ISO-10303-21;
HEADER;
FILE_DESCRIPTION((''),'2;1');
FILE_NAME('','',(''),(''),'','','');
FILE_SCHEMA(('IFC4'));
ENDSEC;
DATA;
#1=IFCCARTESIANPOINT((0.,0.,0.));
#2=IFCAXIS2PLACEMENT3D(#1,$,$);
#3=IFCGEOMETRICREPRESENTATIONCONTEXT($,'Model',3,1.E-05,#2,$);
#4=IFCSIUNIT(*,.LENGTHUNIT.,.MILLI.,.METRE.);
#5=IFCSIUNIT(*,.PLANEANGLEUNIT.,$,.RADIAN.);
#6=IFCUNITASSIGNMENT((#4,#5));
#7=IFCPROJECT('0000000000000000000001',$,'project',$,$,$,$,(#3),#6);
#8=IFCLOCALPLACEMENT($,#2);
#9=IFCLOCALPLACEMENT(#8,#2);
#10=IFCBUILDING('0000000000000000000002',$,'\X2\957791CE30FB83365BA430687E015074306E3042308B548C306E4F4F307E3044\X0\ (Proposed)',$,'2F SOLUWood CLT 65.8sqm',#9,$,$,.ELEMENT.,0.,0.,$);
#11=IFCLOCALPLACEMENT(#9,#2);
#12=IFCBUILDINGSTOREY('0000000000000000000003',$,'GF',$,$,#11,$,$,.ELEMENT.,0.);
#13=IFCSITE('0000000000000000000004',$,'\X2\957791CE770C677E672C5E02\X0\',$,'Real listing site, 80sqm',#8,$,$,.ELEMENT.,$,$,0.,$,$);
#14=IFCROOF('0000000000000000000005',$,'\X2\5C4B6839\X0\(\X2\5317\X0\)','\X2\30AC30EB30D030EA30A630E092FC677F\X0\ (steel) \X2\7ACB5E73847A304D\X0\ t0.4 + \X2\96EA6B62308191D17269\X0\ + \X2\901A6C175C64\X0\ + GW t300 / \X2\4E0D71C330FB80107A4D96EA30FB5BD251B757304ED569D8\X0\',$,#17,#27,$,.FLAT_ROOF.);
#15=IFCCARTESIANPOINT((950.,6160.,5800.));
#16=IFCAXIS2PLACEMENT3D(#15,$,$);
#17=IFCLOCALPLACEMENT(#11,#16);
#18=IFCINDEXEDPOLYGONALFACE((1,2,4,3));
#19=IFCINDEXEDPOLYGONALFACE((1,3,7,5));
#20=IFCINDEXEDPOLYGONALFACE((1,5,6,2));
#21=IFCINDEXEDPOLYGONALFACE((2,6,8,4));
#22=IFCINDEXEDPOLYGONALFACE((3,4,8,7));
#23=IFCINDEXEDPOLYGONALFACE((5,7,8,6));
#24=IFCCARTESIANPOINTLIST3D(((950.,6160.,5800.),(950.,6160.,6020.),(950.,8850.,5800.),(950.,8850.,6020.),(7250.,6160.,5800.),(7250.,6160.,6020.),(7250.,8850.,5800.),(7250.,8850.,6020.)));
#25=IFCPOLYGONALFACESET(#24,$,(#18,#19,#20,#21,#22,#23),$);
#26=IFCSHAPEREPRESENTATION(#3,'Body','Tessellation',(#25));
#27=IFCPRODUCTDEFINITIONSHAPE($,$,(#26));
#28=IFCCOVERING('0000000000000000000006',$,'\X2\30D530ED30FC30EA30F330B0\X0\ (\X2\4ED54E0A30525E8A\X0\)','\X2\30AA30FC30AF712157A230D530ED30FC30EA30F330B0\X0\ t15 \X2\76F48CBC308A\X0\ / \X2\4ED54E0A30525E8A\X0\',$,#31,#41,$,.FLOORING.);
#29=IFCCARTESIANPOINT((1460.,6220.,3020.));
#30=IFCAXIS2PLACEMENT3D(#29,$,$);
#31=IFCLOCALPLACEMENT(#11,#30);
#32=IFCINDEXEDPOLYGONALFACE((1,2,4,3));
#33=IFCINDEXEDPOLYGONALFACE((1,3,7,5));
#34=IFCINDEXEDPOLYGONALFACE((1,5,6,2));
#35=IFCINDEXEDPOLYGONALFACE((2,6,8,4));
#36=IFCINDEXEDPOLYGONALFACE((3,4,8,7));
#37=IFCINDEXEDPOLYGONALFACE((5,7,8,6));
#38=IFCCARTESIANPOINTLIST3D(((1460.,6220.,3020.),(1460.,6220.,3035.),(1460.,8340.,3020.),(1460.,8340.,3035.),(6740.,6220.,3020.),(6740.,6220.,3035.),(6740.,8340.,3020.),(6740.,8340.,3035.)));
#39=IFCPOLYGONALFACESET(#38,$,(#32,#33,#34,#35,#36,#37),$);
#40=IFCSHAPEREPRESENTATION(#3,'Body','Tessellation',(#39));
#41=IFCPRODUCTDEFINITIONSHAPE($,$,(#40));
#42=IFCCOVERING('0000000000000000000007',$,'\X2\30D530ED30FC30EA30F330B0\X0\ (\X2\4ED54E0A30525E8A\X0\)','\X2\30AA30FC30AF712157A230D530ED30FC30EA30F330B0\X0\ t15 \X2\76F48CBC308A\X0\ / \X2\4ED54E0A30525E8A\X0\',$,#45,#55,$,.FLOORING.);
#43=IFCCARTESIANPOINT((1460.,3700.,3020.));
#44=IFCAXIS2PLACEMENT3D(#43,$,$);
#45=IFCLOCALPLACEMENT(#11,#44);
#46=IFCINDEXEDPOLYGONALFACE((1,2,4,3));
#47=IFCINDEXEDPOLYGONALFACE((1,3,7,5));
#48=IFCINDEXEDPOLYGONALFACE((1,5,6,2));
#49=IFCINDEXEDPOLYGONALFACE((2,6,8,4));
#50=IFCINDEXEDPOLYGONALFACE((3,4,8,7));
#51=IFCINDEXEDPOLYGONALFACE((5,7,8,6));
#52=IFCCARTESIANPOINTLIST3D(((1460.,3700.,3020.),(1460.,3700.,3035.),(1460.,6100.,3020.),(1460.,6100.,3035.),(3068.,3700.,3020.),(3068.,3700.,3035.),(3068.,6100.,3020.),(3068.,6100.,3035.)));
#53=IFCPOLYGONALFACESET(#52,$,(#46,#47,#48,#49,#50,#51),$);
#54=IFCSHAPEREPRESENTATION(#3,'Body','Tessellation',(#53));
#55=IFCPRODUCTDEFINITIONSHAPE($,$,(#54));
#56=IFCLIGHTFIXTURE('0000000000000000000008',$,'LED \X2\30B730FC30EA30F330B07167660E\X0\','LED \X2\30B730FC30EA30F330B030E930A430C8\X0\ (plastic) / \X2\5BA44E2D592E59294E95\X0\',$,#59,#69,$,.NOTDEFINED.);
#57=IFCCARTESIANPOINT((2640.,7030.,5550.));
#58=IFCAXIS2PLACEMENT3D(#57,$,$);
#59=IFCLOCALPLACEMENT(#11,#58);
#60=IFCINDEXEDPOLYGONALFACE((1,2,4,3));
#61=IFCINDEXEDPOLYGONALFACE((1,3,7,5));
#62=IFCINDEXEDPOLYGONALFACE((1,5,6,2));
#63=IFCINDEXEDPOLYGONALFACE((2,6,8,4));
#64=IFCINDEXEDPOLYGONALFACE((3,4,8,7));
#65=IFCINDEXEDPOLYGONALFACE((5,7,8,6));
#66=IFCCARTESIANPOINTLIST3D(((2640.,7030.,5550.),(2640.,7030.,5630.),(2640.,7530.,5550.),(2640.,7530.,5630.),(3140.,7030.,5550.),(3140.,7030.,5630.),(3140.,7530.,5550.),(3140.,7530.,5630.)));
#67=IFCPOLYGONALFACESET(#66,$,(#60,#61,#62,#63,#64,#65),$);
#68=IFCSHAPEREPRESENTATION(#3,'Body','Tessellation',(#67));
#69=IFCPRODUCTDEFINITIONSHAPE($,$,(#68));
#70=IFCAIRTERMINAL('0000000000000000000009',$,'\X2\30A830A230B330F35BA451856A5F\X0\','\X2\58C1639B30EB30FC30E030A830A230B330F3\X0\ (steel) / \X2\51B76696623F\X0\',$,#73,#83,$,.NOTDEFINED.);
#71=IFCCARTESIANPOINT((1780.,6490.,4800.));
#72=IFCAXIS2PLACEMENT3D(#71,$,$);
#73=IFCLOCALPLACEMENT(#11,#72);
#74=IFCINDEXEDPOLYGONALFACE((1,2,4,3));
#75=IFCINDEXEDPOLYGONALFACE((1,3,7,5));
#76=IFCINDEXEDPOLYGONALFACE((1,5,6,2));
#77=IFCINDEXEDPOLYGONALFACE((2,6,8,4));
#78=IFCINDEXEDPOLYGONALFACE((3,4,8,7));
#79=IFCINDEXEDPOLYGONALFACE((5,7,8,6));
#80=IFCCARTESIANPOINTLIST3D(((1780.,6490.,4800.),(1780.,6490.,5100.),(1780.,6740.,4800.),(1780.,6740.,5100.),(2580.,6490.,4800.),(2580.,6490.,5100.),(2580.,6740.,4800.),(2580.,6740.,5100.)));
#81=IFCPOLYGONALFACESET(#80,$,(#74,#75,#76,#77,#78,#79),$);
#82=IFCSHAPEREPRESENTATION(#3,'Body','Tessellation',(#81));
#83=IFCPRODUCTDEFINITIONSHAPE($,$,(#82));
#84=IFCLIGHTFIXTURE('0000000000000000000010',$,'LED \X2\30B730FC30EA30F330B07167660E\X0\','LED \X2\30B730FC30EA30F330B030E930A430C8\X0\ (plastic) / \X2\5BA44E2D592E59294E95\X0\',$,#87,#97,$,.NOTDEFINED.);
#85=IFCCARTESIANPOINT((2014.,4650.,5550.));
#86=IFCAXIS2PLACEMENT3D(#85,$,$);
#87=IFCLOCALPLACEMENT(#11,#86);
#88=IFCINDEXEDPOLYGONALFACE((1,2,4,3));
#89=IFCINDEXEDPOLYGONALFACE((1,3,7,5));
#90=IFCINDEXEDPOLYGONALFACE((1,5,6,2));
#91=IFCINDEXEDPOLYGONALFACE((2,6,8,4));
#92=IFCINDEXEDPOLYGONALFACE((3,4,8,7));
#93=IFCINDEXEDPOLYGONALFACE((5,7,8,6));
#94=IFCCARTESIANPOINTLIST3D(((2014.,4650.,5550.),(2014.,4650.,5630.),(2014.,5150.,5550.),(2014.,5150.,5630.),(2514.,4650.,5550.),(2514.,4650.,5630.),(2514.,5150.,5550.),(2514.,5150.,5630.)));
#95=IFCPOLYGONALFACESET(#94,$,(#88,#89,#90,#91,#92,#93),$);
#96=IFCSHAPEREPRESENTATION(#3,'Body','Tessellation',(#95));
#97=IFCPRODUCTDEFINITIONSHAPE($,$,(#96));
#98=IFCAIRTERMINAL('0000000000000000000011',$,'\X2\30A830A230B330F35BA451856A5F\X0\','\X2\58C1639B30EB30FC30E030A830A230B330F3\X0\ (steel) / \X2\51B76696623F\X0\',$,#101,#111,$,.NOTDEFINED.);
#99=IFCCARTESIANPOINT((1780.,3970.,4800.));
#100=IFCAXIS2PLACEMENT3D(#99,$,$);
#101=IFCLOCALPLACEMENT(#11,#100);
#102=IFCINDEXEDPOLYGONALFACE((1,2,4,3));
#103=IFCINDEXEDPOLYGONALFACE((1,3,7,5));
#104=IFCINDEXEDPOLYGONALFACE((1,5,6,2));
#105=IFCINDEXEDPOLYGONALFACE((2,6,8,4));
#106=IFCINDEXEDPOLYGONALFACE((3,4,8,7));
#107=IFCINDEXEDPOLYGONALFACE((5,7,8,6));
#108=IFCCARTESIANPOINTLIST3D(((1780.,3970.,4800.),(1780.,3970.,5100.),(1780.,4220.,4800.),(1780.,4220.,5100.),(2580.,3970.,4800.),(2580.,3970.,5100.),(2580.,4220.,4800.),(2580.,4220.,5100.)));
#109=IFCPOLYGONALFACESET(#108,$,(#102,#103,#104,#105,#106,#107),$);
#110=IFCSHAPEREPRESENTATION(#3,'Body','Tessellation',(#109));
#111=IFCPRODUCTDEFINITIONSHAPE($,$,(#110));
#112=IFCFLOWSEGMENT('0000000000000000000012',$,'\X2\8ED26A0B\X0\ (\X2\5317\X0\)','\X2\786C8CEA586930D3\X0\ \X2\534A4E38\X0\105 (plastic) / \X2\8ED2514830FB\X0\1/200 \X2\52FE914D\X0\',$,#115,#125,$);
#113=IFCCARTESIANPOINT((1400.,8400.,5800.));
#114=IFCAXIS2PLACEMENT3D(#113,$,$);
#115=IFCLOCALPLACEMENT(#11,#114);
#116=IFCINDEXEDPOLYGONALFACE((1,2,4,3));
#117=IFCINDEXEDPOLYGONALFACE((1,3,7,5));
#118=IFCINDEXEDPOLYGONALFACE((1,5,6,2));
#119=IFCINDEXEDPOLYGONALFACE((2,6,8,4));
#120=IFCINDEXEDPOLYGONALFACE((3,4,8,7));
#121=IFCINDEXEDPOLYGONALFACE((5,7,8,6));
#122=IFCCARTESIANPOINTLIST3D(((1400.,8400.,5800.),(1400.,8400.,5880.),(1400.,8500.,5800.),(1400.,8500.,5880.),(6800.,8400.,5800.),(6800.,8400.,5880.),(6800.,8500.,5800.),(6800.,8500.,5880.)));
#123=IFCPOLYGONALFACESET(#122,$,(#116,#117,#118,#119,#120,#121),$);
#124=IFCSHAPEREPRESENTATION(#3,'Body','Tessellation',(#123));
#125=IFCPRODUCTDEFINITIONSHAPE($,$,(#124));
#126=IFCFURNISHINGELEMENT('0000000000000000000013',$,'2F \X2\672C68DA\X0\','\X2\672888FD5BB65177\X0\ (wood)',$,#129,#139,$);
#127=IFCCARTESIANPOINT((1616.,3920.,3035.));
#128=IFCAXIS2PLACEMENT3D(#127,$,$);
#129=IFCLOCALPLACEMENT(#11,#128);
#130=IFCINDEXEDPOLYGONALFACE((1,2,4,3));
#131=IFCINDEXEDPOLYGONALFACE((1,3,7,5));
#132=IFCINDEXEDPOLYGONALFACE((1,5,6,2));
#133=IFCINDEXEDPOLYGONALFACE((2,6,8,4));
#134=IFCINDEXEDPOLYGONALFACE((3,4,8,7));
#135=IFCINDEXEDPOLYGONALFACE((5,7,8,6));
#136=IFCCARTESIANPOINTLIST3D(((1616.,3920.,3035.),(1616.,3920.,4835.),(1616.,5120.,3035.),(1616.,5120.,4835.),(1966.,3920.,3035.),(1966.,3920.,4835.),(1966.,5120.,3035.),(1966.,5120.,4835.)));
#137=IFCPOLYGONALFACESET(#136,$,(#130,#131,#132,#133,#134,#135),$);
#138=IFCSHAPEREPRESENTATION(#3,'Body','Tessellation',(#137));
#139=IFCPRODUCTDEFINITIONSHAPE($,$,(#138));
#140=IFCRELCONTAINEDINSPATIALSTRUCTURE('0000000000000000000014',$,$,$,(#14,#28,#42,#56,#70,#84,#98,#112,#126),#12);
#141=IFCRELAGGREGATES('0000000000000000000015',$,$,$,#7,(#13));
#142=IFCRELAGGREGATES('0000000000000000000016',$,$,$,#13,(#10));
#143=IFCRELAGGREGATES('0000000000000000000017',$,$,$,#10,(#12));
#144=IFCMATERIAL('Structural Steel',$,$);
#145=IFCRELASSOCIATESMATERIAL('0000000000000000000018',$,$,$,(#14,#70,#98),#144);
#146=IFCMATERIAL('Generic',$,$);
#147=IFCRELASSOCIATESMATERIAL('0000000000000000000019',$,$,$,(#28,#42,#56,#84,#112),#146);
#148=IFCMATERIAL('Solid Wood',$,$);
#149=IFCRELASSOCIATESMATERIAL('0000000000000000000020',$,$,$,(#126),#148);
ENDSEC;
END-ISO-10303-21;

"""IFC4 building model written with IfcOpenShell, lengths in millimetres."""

from ifc_helpers import new_model, si_unit, frame, frame_2d, origin, place, context, project, spatial, rectangle, extrude, material, element, save


model = new_model("IFC4")

# Units and contexts
model_context = context("Model", 3, precision=1e-05, world=origin())
ifc_project = project(units=[si_unit("LENGTHUNIT", "METRE", prefix="MILLI"), si_unit("PLANEANGLEUNIT", "RADIAN")], contexts=[model_context])

# Site, building, storey
site_placement = place(None, origin())
site = spatial("IfcSite", under=ifc_project, at=site_placement, Name="長野県松本市", ObjectType="Real listing site, 80sqm", CompositionType="ELEMENT", RefElevation=0.0)
building_placement = place(site_placement, origin())
building = spatial("IfcBuilding", under=site, at=building_placement, Name="長野・茶室と縁側のある和の住まい (Proposed)", ObjectType="2F SOLUWood CLT 65.8sqm", CompositionType="ELEMENT", ElevationOfRefHeight=0.0, ElevationOfTerrain=0.0)
storey_placement = place(building_placement, origin())
storey = spatial("IfcBuildingStorey", under=building, at=storey_placement, Name="GF", CompositionType="ELEMENT", Elevation=0.0)

# Shared definitions
ifc_material_1 = material(Name="Solid Wood")

# Roof
ifc_material_2 = material(Name="Structural Steel")
for number, where, name in (
    (1, (950.0, 6160.0, 5800.0), "屋根(北)"),
):
    element("IfcRoof", number, at=place(storey_placement, frame(where)), inside=storey, material=ifc_material_2, Name=name, Description="ガルバリウム鋼板 (steel) 立平葺き t0.4 + 雪止め金物 + 通気層 + GW t300 / 不燃・耐積雪・寒冷地仕様", PredefinedType="FLAT_ROOF", context=model_context, shape_type="SweptSolid", body=[
        extrude(rectangle(XDim=6300.0, YDim=2690.0, at=frame_2d((3150.0, 1345.0))), frame((950.0, 6160.0, 5800.0)), (0.0, 0.0, 1.0), 220.0),
    ])

# Coverings
ifc_material_3 = material(Name="Generic")
covering_1_placement = place(storey_placement, frame((1460.0, 6220.0, 3020.0)))
element("IfcCovering", 2, at=covering_1_placement, inside=storey, material=ifc_material_3, Name="フローリング (仕上げ床)", Description="オーク無垢フローリング t15 直貼り / 仕上げ床", PredefinedType="FLOORING", context=model_context, shape_type="SweptSolid", body=[
    extrude(rectangle(XDim=5280.0, YDim=2120.0, at=frame_2d((2640.0, 1060.0))), frame((1460.0, 6220.0, 3020.0)), (0.0, 0.0, 1.0), 15.0),
])
covering_2_placement = place(storey_placement, frame((1460.0, 3700.0, 3020.0)))
element("IfcCovering", 3, at=covering_2_placement, inside=storey, material=ifc_material_3, Name="フローリング (仕上げ床)", Description="オーク無垢フローリング t15 直貼り / 仕上げ床", PredefinedType="FLOORING", context=model_context, shape_type="SweptSolid", body=[
    extrude(rectangle(XDim=1608.0, YDim=2400.0, at=frame_2d((804.0, 1200.0))), frame((1460.0, 3700.0, 3020.0)), (0.0, 0.0, 1.0), 15.0),
])

# Light fixture
light_fixture_1_placement = place(storey_placement, frame((2640.0, 7030.0, 5550.0)))
element("IfcLightFixture", 4, at=light_fixture_1_placement, inside=storey, material=ifc_material_3, Name="LED シーリング照明", Description="LED シーリングライト (plastic) / 室中央天井", PredefinedType="NOTDEFINED", context=model_context, shape_type="SweptSolid", body=[
    extrude(rectangle(XDim=500.0, YDim=500.0, at=frame_2d((250.0, 250.0))), frame((2640.0, 7030.0, 5550.0)), (0.0, 0.0, 1.0), 80.0),
])

# Air terminal
air_terminal_1_placement = place(storey_placement, frame((1780.0, 6490.0, 4800.0)))
element("IfcAirTerminal", 5, at=air_terminal_1_placement, inside=storey, material=ifc_material_2, Name="エアコン室内機", Description="壁掛ルームエアコン (steel) / 冷暖房", PredefinedType="NOTDEFINED", context=model_context, shape_type="SweptSolid", body=[
    extrude(rectangle(XDim=800.0, YDim=250.0, at=frame_2d((400.0, 125.0))), frame((1780.0, 6490.0, 4800.0)), (0.0, 0.0, 1.0), 300.0),
])

# Light fixture
light_fixture_2_placement = place(storey_placement, frame((2014.0, 4650.0, 5550.0)))
element("IfcLightFixture", 6, at=light_fixture_2_placement, inside=storey, material=ifc_material_3, Name="LED シーリング照明", Description="LED シーリングライト (plastic) / 室中央天井", PredefinedType="NOTDEFINED", context=model_context, shape_type="SweptSolid", body=[
    extrude(rectangle(XDim=500.0, YDim=500.0, at=frame_2d((250.0, 250.0))), frame((2014.0, 4650.0, 5550.0)), (0.0, 0.0, 1.0), 80.0),
])

# Air terminal
air_terminal_2_placement = place(storey_placement, frame((1780.0, 3970.0, 4800.0)))
element("IfcAirTerminal", 7, at=air_terminal_2_placement, inside=storey, material=ifc_material_2, Name="エアコン室内機", Description="壁掛ルームエアコン (steel) / 冷暖房", PredefinedType="NOTDEFINED", context=model_context, shape_type="SweptSolid", body=[
    extrude(rectangle(XDim=800.0, YDim=250.0, at=frame_2d((400.0, 125.0))), frame((1780.0, 3970.0, 4800.0)), (0.0, 0.0, 1.0), 300.0),
])

# Flow segment
flow_segment_placement = place(storey_placement, frame((1400.0, 8400.0, 5800.0)))
element("IfcFlowSegment", 8, at=flow_segment_placement, inside=storey, material=ifc_material_3, Name="軒樋 (北)", Description="硬質塩ビ 半丸105 (plastic) / 軒先・1/200 勾配", context=model_context, shape_type="SweptSolid", body=[
    extrude(rectangle(XDim=5400.0, YDim=100.0, at=frame_2d((2700.0, 50.0))), frame((1400.0, 8400.0, 5800.0)), (0.0, 0.0, 1.0), 80.0),
])

# Furnishing element
furnishing_placement = place(storey_placement, frame((1616.0, 3920.0, 3035.0)))
element("IfcFurnishingElement", 9, at=furnishing_placement, inside=storey, material=ifc_material_1, Name="2F 本棚", Description="木製家具 (wood)", context=model_context, shape_type="SweptSolid", body=[
    extrude(rectangle(XDim=350.0, YDim=1200.0, at=frame_2d((175.0, 600.0))), frame((1616.0, 3920.0, 3035.0)), (0.0, 0.0, 1.0), 1800.0),
])

save(model, "model.ifc")
